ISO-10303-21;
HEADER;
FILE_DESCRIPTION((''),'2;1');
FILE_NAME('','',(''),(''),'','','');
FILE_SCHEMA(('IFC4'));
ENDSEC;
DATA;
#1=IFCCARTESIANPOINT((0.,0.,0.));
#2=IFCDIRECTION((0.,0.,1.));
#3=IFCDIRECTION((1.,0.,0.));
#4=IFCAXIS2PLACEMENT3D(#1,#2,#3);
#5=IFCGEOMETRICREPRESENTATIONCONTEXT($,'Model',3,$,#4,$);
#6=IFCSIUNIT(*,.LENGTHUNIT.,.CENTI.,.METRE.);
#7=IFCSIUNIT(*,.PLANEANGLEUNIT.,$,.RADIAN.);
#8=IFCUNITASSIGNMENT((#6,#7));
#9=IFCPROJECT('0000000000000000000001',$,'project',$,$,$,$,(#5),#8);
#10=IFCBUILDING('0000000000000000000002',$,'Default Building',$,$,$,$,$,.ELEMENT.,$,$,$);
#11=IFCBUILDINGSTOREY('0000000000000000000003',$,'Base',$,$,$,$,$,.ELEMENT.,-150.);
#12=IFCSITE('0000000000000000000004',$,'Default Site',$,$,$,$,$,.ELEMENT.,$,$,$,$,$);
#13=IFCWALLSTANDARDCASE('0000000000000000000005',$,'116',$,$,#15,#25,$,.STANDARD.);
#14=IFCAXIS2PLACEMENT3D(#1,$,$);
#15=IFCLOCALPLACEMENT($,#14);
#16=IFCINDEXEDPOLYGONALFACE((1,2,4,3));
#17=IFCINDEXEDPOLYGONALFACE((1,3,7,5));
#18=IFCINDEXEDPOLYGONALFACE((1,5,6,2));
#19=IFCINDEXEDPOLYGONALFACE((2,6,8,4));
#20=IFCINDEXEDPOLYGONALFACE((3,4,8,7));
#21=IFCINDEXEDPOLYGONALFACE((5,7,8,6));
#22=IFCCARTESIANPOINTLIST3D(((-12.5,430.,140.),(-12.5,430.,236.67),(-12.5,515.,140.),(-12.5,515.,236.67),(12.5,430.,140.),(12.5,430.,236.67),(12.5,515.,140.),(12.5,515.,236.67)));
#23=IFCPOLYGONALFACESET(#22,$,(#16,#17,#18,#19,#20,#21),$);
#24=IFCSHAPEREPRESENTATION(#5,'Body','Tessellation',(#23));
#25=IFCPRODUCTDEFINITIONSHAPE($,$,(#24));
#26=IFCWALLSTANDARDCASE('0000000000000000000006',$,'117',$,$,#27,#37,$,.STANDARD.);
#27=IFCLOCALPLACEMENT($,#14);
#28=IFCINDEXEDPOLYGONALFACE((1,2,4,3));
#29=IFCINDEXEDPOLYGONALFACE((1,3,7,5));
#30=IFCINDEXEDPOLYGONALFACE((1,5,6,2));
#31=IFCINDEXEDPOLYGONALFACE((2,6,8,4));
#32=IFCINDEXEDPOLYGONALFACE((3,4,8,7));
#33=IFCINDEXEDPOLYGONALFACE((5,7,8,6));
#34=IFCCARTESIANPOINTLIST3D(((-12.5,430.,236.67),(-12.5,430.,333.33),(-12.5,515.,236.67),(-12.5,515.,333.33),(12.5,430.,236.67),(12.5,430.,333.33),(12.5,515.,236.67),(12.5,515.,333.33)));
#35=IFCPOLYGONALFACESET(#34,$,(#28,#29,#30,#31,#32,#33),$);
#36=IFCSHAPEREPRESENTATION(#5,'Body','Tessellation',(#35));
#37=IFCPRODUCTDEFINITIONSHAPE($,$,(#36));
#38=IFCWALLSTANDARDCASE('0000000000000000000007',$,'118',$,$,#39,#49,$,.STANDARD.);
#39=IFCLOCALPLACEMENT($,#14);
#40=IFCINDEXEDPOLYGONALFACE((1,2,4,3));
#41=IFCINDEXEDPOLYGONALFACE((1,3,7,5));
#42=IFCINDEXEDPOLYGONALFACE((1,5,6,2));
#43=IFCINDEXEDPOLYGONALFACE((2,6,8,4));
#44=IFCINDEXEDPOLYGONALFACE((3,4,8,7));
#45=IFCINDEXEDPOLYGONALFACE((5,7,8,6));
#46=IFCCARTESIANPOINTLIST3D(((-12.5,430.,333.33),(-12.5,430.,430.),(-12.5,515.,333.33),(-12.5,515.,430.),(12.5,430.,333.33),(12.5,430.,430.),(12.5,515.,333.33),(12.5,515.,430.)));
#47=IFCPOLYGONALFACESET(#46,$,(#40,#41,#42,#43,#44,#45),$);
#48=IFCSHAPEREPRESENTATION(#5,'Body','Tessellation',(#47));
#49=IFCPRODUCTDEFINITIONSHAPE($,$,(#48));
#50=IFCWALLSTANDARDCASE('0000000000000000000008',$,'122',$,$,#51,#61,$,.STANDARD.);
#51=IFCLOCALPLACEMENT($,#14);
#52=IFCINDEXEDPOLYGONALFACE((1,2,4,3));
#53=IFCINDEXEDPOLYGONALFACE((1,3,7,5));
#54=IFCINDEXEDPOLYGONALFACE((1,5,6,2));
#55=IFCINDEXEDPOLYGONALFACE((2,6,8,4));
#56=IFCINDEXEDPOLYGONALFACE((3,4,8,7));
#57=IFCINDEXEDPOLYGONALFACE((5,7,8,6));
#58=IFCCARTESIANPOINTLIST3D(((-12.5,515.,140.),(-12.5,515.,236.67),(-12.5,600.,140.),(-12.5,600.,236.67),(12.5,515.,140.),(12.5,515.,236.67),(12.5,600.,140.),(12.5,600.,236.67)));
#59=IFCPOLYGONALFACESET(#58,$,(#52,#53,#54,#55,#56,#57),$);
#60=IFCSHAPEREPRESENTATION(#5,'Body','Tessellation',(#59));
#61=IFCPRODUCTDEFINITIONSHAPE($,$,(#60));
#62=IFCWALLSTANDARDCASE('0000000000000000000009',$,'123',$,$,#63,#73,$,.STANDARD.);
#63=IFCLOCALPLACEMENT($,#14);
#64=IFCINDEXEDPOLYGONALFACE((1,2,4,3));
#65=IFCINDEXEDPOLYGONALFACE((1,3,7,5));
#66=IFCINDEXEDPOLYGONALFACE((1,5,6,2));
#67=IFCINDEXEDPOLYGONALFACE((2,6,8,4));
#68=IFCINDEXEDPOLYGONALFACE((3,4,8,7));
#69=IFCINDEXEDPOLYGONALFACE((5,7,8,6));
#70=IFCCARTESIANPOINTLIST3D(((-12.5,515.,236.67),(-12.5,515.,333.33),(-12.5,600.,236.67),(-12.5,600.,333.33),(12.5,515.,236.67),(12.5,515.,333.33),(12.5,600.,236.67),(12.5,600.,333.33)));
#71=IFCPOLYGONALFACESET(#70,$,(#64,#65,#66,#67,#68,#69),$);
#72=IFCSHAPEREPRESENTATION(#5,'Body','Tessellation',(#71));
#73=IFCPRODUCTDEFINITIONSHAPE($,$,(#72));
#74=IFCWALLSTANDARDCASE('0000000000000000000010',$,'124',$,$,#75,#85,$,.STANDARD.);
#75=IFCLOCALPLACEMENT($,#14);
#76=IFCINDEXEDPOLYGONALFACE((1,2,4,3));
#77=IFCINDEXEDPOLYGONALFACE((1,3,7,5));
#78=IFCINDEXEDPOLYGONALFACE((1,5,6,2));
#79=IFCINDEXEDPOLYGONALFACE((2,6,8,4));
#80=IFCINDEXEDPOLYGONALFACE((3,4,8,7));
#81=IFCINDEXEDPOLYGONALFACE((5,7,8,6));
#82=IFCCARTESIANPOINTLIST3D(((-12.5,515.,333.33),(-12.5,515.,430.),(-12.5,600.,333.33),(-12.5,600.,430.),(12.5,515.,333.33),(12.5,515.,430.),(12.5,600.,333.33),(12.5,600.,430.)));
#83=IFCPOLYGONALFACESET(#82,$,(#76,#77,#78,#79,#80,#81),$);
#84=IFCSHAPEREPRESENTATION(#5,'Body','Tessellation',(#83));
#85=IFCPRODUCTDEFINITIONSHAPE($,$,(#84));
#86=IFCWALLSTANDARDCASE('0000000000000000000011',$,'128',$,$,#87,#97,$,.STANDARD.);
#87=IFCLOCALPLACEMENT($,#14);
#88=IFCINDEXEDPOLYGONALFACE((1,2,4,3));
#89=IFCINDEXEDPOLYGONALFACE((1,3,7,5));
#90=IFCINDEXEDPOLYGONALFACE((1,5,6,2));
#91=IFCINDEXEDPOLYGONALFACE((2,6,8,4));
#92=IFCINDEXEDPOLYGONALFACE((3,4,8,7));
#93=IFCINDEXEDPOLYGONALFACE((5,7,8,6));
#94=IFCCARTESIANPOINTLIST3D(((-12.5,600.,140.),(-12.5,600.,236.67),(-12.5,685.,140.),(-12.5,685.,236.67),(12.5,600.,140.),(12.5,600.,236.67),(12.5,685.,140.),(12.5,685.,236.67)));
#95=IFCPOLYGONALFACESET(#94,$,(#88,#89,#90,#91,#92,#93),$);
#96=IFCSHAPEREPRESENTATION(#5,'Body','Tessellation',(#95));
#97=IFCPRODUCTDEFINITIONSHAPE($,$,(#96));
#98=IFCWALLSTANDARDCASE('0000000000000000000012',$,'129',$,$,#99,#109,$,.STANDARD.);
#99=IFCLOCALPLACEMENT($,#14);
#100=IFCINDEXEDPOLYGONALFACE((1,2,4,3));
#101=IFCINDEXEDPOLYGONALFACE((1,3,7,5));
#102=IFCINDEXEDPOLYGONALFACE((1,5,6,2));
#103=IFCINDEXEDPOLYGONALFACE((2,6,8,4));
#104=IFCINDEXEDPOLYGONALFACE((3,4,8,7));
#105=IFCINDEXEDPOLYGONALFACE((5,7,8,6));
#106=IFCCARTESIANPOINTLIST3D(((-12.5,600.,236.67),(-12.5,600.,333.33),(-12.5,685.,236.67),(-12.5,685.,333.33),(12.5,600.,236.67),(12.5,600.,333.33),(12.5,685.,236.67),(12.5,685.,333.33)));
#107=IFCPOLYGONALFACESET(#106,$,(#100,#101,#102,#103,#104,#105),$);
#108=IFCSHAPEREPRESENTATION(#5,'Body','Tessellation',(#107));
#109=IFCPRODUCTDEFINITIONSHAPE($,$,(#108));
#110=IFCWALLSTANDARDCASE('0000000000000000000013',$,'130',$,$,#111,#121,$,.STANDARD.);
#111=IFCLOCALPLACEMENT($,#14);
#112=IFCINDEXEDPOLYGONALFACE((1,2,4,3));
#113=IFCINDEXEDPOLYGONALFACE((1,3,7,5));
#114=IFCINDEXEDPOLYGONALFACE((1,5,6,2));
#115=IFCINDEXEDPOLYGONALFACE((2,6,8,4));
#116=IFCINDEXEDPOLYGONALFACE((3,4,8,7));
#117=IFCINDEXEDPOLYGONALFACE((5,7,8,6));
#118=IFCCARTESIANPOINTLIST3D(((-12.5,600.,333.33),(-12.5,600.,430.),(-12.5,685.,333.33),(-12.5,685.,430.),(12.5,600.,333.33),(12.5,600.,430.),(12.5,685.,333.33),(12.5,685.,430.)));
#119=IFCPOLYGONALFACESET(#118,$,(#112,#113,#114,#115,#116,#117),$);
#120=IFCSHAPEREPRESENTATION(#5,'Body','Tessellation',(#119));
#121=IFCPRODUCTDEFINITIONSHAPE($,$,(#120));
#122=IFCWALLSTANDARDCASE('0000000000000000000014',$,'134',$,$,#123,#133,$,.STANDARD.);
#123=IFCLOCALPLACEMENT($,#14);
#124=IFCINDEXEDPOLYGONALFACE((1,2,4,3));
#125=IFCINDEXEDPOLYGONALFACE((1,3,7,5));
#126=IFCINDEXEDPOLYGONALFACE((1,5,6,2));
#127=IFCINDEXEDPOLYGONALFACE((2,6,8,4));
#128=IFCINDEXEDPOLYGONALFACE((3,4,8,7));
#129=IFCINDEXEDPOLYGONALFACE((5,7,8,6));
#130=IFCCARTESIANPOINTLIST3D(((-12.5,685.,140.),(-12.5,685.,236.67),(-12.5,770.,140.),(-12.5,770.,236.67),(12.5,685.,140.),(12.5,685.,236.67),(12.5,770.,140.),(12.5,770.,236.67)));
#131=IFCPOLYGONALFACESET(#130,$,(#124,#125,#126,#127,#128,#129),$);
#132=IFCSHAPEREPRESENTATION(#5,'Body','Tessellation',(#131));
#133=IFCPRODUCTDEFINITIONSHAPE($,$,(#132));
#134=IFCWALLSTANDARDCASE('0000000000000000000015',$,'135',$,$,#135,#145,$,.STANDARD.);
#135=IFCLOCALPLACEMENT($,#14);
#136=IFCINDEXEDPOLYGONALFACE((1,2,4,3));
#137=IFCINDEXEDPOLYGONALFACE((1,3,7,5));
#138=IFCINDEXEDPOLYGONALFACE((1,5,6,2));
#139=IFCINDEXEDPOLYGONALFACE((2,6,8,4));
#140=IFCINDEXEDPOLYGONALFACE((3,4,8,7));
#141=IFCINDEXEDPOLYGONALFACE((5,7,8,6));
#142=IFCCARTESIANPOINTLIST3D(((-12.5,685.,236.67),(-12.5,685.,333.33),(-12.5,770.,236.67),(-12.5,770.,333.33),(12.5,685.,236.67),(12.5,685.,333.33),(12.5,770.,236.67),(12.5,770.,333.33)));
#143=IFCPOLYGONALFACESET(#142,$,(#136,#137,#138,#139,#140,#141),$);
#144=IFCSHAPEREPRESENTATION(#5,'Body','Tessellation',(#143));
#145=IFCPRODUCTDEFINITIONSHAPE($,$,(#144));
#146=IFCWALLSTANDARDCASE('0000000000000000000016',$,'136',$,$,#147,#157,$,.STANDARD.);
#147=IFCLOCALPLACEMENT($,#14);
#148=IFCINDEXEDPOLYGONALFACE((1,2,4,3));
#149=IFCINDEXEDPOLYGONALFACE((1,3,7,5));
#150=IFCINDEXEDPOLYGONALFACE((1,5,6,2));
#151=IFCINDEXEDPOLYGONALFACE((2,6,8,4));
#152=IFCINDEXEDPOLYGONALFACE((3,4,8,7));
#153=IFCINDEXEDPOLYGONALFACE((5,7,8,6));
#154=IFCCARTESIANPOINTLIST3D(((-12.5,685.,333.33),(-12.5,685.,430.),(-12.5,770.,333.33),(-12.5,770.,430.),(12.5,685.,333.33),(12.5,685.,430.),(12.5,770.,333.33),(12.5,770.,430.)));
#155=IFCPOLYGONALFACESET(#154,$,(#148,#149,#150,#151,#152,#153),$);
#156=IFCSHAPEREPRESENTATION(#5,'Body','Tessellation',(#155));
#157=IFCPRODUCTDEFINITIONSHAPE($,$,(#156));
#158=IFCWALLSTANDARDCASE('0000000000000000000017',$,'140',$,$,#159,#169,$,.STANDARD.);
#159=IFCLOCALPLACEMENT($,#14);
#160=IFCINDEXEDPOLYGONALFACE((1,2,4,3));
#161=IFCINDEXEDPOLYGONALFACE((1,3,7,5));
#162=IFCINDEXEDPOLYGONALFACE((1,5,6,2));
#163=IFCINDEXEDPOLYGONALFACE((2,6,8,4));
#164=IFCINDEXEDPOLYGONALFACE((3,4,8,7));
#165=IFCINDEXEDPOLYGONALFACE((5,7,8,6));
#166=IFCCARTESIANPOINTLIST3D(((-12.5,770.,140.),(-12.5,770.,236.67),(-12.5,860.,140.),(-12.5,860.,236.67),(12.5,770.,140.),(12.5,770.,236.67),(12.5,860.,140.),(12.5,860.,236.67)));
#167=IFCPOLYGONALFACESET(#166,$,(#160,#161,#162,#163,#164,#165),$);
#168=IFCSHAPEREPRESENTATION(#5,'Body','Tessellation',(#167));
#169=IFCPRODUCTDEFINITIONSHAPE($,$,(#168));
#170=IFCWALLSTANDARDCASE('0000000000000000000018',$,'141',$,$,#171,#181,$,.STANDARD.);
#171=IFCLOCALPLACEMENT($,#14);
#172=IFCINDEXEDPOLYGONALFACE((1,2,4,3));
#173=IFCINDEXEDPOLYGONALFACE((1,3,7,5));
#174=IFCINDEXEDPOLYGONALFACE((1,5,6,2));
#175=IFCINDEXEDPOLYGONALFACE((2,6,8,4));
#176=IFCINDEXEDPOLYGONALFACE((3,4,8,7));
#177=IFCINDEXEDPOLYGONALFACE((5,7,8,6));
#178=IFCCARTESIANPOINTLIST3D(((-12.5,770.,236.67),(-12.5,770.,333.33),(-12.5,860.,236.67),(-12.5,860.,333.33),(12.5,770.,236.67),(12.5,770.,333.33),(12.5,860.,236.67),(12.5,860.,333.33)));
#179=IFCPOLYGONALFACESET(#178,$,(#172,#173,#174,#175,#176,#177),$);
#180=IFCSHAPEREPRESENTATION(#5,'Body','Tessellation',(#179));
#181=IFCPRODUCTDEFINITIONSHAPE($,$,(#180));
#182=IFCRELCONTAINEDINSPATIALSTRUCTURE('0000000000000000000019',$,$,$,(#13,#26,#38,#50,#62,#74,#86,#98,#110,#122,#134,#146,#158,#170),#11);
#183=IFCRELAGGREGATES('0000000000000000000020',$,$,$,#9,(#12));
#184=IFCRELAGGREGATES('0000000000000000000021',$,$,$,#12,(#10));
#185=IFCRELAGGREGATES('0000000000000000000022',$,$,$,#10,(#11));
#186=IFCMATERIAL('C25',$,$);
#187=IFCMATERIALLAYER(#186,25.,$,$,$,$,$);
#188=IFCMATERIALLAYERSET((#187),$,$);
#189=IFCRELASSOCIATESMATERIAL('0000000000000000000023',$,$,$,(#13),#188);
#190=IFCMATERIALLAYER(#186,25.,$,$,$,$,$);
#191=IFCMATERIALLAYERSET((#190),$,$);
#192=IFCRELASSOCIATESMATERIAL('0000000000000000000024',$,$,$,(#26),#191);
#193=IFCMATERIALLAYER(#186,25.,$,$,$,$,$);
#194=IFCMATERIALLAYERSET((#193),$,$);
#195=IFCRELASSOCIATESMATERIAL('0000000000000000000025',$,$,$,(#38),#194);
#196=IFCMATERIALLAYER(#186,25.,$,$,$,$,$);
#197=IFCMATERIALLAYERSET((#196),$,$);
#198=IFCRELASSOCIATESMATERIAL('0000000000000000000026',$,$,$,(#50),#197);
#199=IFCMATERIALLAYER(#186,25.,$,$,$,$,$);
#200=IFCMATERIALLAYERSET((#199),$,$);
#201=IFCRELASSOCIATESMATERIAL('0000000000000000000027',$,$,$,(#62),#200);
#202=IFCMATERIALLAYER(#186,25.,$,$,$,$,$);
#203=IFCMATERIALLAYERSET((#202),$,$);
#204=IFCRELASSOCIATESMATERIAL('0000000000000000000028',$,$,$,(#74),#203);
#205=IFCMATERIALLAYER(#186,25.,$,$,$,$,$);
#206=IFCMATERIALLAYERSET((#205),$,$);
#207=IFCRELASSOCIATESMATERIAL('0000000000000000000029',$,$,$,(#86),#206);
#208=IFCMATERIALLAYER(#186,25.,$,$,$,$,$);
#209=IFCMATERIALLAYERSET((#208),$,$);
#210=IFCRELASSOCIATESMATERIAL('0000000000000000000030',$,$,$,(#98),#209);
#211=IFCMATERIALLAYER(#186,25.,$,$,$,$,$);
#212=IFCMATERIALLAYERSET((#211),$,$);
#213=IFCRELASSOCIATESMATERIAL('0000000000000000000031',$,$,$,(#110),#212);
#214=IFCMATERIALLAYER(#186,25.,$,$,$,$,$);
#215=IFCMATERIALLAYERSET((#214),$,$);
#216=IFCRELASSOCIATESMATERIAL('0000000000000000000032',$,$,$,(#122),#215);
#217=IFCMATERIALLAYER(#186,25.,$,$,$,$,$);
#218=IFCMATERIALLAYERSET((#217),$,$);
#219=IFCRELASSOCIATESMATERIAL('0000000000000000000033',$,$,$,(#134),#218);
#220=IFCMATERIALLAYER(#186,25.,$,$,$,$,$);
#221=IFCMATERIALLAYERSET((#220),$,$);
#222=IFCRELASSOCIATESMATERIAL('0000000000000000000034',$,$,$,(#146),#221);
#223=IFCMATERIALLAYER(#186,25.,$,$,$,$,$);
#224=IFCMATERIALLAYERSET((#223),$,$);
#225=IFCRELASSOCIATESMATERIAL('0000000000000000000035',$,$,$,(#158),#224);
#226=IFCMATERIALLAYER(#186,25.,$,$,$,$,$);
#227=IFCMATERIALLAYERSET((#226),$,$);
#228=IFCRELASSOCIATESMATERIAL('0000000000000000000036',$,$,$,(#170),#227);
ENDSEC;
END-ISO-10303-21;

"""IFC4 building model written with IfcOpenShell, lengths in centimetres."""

from ifc_helpers import new_model, si_unit, frame, origin_with_axes, origin_2d_with_axis, place, context, project, spatial, rectangle, extrude, material, layer, layer_set, layer_usage, element, save


model = new_model("IFC4")

# Units and contexts
model_context = context("Model", 3, world=origin_with_axes())
ifc_project = project(units=[si_unit("LENGTHUNIT", "METRE", prefix="CENTI"), si_unit("PLANEANGLEUNIT", "RADIAN")], contexts=[model_context])

# Site, building, storey
site = spatial("IfcSite", under=ifc_project, Name="Default Site", CompositionType="ELEMENT")
building = spatial("IfcBuilding", under=site, Name="Default Building", CompositionType="ELEMENT")
storey = spatial("IfcBuildingStorey", under=building, Name="Base", CompositionType="ELEMENT", Elevation=-150.0)

# Walls
ifc_material = material(Name="C25")
ifc_layer_1 = layer(ifc_material, 25.0)
ifc_layer_set_1 = layer_set([ifc_layer_1])
ifc_layer_usage_1 = layer_usage(ifc_layer_set_1, "AXIS2", "POSITIVE", -25.0)
wall_1_placement = place(None, frame((0.0, 472.5, 140.0), z_axis=(0.0, 0.0, 1.0), x_axis=(0.0, 1.0, 0.0)))
element("IfcWallStandardCase", 1, at=wall_1_placement, inside=storey, material=ifc_layer_usage_1, Name="116", PredefinedType="STANDARD", context=model_context, shape_type="SweptSolid", body=[
    extrude(rectangle(XDim=85.0, YDim=25.0, at=origin_2d_with_axis()), origin_with_axes(), (0.0, 0.0, 1.0), 96.67),
])
ifc_layer_2 = layer(ifc_material, 25.0)
ifc_layer_set_2 = layer_set([ifc_layer_2])
ifc_layer_usage_2 = layer_usage(ifc_layer_set_2, "AXIS2", "POSITIVE", -25.0)
wall_2_placement = place(None, frame((0.0, 472.5, 236.67), z_axis=(0.0, 0.0, 1.0), x_axis=(0.0, 1.0, 0.0)))
element("IfcWallStandardCase", 2, at=wall_2_placement, inside=storey, material=ifc_layer_usage_2, Name="117", PredefinedType="STANDARD", context=model_context, shape_type="SweptSolid", body=[
    extrude(rectangle(XDim=85.0, YDim=25.0, at=origin_2d_with_axis()), origin_with_axes(), (0.0, 0.0, 1.0), 96.67),
])
ifc_layer_3 = layer(ifc_material, 25.0)
ifc_layer_set_3 = layer_set([ifc_layer_3])
ifc_layer_usage_3 = layer_usage(ifc_layer_set_3, "AXIS2", "POSITIVE", -25.0)
wall_3_placement = place(None, frame((0.0, 472.5, 333.33), z_axis=(0.0, 0.0, 1.0), x_axis=(0.0, 1.0, 0.0)))
element("IfcWallStandardCase", 3, at=wall_3_placement, inside=storey, material=ifc_layer_usage_3, Name="118", PredefinedType="STANDARD", context=model_context, shape_type="SweptSolid", body=[
    extrude(rectangle(XDim=85.0, YDim=25.0, at=origin_2d_with_axis()), origin_with_axes(), (0.0, 0.0, 1.0), 96.67),
])
ifc_layer_4 = layer(ifc_material, 25.0)
ifc_layer_set_4 = layer_set([ifc_layer_4])
ifc_layer_usage_4 = layer_usage(ifc_layer_set_4, "AXIS2", "POSITIVE", -25.0)
wall_4_placement = place(None, frame((0.0, 557.5, 140.0), z_axis=(0.0, 0.0, 1.0), x_axis=(0.0, 1.0, 0.0)))
element("IfcWallStandardCase", 4, at=wall_4_placement, inside=storey, material=ifc_layer_usage_4, Name="122", PredefinedType="STANDARD", context=model_context, shape_type="SweptSolid", body=[
    extrude(rectangle(XDim=85.0, YDim=25.0, at=origin_2d_with_axis()), origin_with_axes(), (0.0, 0.0, 1.0), 96.67),
])
ifc_layer_5 = layer(ifc_material, 25.0)
ifc_layer_set_5 = layer_set([ifc_layer_5])
ifc_layer_usage_5 = layer_usage(ifc_layer_set_5, "AXIS2", "POSITIVE", -25.0)
wall_5_placement = place(None, frame((0.0, 557.5, 236.67), z_axis=(0.0, 0.0, 1.0), x_axis=(0.0, 1.0, 0.0)))
element("IfcWallStandardCase", 5, at=wall_5_placement, inside=storey, material=ifc_layer_usage_5, Name="123", PredefinedType="STANDARD", context=model_context, shape_type="SweptSolid", body=[
    extrude(rectangle(XDim=85.0, YDim=25.0, at=origin_2d_with_axis()), origin_with_axes(), (0.0, 0.0, 1.0), 96.67),
])
ifc_layer_6 = layer(ifc_material, 25.0)
ifc_layer_set_6 = layer_set([ifc_layer_6])
ifc_layer_usage_6 = layer_usage(ifc_layer_set_6, "AXIS2", "POSITIVE", -25.0)
wall_6_placement = place(None, frame((0.0, 557.5, 333.33), z_axis=(0.0, 0.0, 1.0), x_axis=(0.0, 1.0, 0.0)))
element("IfcWallStandardCase", 6, at=wall_6_placement, inside=storey, material=ifc_layer_usage_6, Name="124", PredefinedType="STANDARD", context=model_context, shape_type="SweptSolid", body=[
    extrude(rectangle(XDim=85.0, YDim=25.0, at=origin_2d_with_axis()), origin_with_axes(), (0.0, 0.0, 1.0), 96.67),
])
ifc_layer_7 = layer(ifc_material, 25.0)
ifc_layer_set_7 = layer_set([ifc_layer_7])
ifc_layer_usage_7 = layer_usage(ifc_layer_set_7, "AXIS2", "POSITIVE", -25.0)
wall_7_placement = place(None, frame((0.0, 642.5, 140.0), z_axis=(0.0, 0.0, 1.0), x_axis=(0.0, 1.0, 0.0)))
element("IfcWallStandardCase", 7, at=wall_7_placement, inside=storey, material=ifc_layer_usage_7, Name="128", PredefinedType="STANDARD", context=model_context, shape_type="SweptSolid", body=[
    extrude(rectangle(XDim=85.0, YDim=25.0, at=origin_2d_with_axis()), origin_with_axes(), (0.0, 0.0, 1.0), 96.67),
])
ifc_layer_8 = layer(ifc_material, 25.0)
ifc_layer_set_8 = layer_set([ifc_layer_8])
ifc_layer_usage_8 = layer_usage(ifc_layer_set_8, "AXIS2", "POSITIVE", -25.0)
wall_8_placement = place(None, frame((0.0, 642.5, 236.67), z_axis=(0.0, 0.0, 1.0), x_axis=(0.0, 1.0, 0.0)))
element("IfcWallStandardCase", 8, at=wall_8_placement, inside=storey, material=ifc_layer_usage_8, Name="129", PredefinedType="STANDARD", context=model_context, shape_type="SweptSolid", body=[
    extrude(rectangle(XDim=85.0, YDim=25.0, at=origin_2d_with_axis()), origin_with_axes(), (0.0, 0.0, 1.0), 96.67),
])
ifc_layer_9 = layer(ifc_material, 25.0)
ifc_layer_set_9 = layer_set([ifc_layer_9])
ifc_layer_usage_9 = layer_usage(ifc_layer_set_9, "AXIS2", "POSITIVE", -25.0)
wall_9_placement = place(None, frame((0.0, 642.5, 333.33), z_axis=(0.0, 0.0, 1.0), x_axis=(0.0, 1.0, 0.0)))
element("IfcWallStandardCase", 9, at=wall_9_placement, inside=storey, material=ifc_layer_usage_9, Name="130", PredefinedType="STANDARD", context=model_context, shape_type="SweptSolid", body=[
    extrude(rectangle(XDim=85.0, YDim=25.0, at=origin_2d_with_axis()), origin_with_axes(), (0.0, 0.0, 1.0), 96.67),
])
ifc_layer_10 = layer(ifc_material, 25.0)
ifc_layer_set_10 = layer_set([ifc_layer_10])
ifc_layer_usage_10 = layer_usage(ifc_layer_set_10, "AXIS2", "POSITIVE", -25.0)
wall_10_placement = place(None, frame((0.0, 727.5, 140.0), z_axis=(0.0, 0.0, 1.0), x_axis=(0.0, 1.0, 0.0)))
element("IfcWallStandardCase", 10, at=wall_10_placement, inside=storey, material=ifc_layer_usage_10, Name="134", PredefinedType="STANDARD", context=model_context, shape_type="SweptSolid", body=[
    extrude(rectangle(XDim=85.0, YDim=25.0, at=origin_2d_with_axis()), origin_with_axes(), (0.0, 0.0, 1.0), 96.67),
])
ifc_layer_11 = layer(ifc_material, 25.0)
ifc_layer_set_11 = layer_set([ifc_layer_11])
ifc_layer_usage_11 = layer_usage(ifc_layer_set_11, "AXIS2", "POSITIVE", -25.0)
wall_11_placement = place(None, frame((0.0, 727.5, 236.67), z_axis=(0.0, 0.0, 1.0), x_axis=(0.0, 1.0, 0.0)))
element("IfcWallStandardCase", 11, at=wall_11_placement, inside=storey, material=ifc_layer_usage_11, Name="135", PredefinedType="STANDARD", context=model_context, shape_type="SweptSolid", body=[
    extrude(rectangle(XDim=85.0, YDim=25.0, at=origin_2d_with_axis()), origin_with_axes(), (0.0, 0.0, 1.0), 96.67),
])
ifc_layer_12 = layer(ifc_material, 25.0)
ifc_layer_set_12 = layer_set([ifc_layer_12])
ifc_layer_usage_12 = layer_usage(ifc_layer_set_12, "AXIS2", "POSITIVE", -25.0)
wall_12_placement = place(None, frame((0.0, 727.5, 333.33), z_axis=(0.0, 0.0, 1.0), x_axis=(0.0, 1.0, 0.0)))
element("IfcWallStandardCase", 12, at=wall_12_placement, inside=storey, material=ifc_layer_usage_12, Name="136", PredefinedType="STANDARD", context=model_context, shape_type="SweptSolid", body=[
    extrude(rectangle(XDim=85.0, YDim=25.0, at=origin_2d_with_axis()), origin_with_axes(), (0.0, 0.0, 1.0), 96.67),
])
ifc_layer_13 = layer(ifc_material, 25.0)
ifc_layer_set_13 = layer_set([ifc_layer_13])
ifc_layer_usage_13 = layer_usage(ifc_layer_set_13, "AXIS2", "POSITIVE", -25.0)
wall_13_placement = place(None, frame((0.0, 815.0, 140.0), z_axis=(0.0, 0.0, 1.0), x_axis=(0.0, 1.0, 0.0)))
element("IfcWallStandardCase", 13, at=wall_13_placement, inside=storey, material=ifc_layer_usage_13, Name="140", PredefinedType="STANDARD", context=model_context, shape_type="SweptSolid", body=[
    extrude(rectangle(XDim=90.0, YDim=25.0, at=origin_2d_with_axis()), origin_with_axes(), (0.0, 0.0, 1.0), 96.67),
])
ifc_layer_14 = layer(ifc_material, 25.0)
ifc_layer_set_14 = layer_set([ifc_layer_14])
ifc_layer_usage_14 = layer_usage(ifc_layer_set_14, "AXIS2", "POSITIVE", -25.0)
wall_14_placement = place(None, frame((0.0, 815.0, 236.67), z_axis=(0.0, 0.0, 1.0), x_axis=(0.0, 1.0, 0.0)))
element("IfcWallStandardCase", 14, at=wall_14_placement, inside=storey, material=ifc_layer_usage_14, Name="141", PredefinedType="STANDARD", context=model_context, shape_type="SweptSolid", body=[
    extrude(rectangle(XDim=90.0, YDim=25.0, at=origin_2d_with_axis()), origin_with_axes(), (0.0, 0.0, 1.0), 96.67),
])

save(model, "model.ifc")
